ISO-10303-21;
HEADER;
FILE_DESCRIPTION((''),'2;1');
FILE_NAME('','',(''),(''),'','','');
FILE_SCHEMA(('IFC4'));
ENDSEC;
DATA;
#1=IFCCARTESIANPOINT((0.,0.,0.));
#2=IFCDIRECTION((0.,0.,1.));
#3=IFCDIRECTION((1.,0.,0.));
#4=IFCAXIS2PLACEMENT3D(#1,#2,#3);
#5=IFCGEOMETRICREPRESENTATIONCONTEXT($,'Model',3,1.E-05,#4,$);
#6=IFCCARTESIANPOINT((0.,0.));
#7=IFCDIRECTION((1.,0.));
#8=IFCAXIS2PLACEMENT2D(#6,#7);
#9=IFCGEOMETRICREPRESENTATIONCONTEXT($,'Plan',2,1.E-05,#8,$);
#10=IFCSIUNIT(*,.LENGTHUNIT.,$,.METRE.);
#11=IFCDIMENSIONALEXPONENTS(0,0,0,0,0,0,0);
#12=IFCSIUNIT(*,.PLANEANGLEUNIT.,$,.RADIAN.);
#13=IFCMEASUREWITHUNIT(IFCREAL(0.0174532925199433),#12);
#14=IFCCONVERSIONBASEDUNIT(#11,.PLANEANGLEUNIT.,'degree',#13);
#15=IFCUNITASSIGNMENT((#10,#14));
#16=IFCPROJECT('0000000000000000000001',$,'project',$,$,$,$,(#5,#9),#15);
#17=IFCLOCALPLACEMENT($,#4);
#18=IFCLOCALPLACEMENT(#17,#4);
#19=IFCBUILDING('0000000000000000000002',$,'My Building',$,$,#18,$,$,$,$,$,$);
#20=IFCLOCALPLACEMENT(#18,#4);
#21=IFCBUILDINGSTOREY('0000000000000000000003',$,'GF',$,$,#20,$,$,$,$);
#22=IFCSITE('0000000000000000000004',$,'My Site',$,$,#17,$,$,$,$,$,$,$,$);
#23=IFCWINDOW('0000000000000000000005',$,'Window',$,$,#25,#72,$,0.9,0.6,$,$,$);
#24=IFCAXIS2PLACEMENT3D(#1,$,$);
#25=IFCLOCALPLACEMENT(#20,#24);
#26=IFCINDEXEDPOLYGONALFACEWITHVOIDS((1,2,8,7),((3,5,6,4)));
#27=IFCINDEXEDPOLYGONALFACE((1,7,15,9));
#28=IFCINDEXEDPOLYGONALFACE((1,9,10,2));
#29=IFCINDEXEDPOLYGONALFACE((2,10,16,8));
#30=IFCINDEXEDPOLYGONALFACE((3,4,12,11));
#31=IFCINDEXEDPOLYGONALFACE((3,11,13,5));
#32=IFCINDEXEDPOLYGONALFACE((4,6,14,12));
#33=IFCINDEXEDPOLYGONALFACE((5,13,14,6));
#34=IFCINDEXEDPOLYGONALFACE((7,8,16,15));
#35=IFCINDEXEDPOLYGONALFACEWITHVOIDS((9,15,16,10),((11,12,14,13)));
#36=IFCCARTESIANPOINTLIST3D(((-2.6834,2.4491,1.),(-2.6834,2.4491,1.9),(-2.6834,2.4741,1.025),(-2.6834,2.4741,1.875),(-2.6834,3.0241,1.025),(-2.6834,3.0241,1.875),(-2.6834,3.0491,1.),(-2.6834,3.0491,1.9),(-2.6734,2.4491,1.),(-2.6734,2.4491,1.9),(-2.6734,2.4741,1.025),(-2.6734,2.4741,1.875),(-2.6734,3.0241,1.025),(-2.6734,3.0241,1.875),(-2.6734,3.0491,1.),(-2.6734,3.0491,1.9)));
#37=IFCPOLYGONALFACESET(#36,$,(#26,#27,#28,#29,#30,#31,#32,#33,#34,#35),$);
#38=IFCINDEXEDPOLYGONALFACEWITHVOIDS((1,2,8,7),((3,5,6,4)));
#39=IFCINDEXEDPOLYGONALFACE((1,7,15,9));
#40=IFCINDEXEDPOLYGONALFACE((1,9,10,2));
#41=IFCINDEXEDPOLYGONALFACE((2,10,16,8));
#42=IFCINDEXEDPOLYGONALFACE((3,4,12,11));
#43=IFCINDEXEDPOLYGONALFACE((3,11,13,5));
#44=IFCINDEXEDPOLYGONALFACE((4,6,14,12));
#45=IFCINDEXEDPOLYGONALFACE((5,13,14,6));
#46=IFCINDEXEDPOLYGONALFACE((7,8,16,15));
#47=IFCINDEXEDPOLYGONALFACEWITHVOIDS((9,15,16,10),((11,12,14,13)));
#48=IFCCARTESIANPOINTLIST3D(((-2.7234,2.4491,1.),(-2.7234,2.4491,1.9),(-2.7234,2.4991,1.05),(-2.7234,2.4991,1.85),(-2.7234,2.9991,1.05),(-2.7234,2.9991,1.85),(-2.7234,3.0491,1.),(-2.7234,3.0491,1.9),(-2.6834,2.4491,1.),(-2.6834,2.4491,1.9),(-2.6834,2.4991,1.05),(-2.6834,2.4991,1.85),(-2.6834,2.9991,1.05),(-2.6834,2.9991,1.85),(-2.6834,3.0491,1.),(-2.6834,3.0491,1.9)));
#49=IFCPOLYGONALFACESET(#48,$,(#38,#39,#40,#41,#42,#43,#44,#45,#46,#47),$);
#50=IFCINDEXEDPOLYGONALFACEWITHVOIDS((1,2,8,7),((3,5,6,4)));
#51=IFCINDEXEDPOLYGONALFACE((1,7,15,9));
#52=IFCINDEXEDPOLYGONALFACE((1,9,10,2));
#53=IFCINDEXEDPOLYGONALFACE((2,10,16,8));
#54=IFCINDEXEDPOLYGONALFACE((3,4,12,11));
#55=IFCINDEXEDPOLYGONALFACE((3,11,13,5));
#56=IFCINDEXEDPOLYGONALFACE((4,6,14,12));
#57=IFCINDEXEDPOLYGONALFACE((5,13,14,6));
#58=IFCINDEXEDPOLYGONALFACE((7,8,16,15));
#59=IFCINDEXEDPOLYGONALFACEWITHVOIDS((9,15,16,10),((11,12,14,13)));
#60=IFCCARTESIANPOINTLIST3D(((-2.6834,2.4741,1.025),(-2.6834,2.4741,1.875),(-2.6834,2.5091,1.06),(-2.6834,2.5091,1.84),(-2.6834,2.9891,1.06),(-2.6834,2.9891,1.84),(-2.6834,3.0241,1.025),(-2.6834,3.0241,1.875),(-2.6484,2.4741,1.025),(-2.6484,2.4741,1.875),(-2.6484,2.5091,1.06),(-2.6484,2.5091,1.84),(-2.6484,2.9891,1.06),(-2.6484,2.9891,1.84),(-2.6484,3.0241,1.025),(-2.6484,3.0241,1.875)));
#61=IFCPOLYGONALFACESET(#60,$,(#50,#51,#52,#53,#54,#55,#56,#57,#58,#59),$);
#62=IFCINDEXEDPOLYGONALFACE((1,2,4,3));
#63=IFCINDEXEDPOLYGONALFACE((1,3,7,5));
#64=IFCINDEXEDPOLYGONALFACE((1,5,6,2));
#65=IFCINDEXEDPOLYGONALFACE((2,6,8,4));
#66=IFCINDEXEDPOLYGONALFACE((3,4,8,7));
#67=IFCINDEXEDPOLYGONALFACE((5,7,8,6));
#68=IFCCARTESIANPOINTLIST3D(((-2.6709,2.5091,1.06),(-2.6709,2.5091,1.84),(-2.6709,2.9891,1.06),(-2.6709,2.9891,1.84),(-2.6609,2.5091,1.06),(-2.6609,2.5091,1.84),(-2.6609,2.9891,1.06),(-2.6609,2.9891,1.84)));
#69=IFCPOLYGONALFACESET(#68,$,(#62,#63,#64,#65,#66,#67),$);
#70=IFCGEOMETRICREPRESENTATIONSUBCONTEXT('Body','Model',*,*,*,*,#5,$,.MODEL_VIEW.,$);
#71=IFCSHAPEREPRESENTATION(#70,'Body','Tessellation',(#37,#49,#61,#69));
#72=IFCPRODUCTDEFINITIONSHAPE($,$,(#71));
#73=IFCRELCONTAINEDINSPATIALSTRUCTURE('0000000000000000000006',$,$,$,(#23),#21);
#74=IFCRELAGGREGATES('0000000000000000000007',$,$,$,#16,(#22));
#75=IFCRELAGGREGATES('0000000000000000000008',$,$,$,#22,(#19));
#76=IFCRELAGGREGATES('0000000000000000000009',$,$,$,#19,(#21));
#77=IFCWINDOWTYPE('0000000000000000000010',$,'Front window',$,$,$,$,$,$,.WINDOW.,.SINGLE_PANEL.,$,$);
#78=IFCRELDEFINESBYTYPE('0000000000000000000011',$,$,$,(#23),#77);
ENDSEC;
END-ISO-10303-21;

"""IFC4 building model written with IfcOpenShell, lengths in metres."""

from ifc_helpers import new_model, entity, si_unit, converted_unit, frame, origin_with_axes, origin_2d_with_axis, place, context, subcontext, project, spatial, line, indexed_curve, outline, extrude, shape, source, transform, mapped, type_object, type_shapes, element, save


model = new_model("IFC4")

# Units and contexts
model_context = context("Model", 3, precision=1e-05, world=origin_with_axes())
plan_context = context("Plan", 2, precision=1e-05, world=origin_2d_with_axis())
body_context_1 = subcontext(model_context, "Body", "Model", "MODEL_VIEW")
body_context_2 = subcontext(plan_context, "Body", "Plan", "PLAN_VIEW")
ifc_project = project(units=[si_unit("LENGTHUNIT", "METRE"), converted_unit("PLANEANGLEUNIT", "degree", entity("IfcReal", 0.0174532925199433), si_unit("PLANEANGLEUNIT", "RADIAN"), dimensions=[0, 0, 0, 0, 0, 0, 0])], contexts=[model_context, plan_context])

# Site, building, storey
site_placement = place(None, origin_with_axes())
site = spatial("IfcSite", under=ifc_project, at=site_placement, Name="My Site")
building_placement = place(site_placement, origin_with_axes())
building = spatial("IfcBuilding", under=site, at=building_placement, Name="My Building")
storey_placement = place(building_placement, origin_with_axes())
storey = spatial("IfcBuildingStorey", under=building, at=storey_placement, Name="GF")

# Shared definitions
window_type_1 = type_object("IfcWindowType", Name="Front window", PartitioningType="SINGLE_PANEL", PredefinedType="WINDOW")
shared_shape_1 = source(origin_with_axes(), body_context_1, "Body", "SweptSolid", [
    extrude(outline(indexed_curve([(0.0, 0.0), (0.6, 0.0), (0.6, 0.9), (0.0, 0.9)], segments=[line(1, 2, 3, 4, 1)]), holes=[indexed_curve([(0.025, 0.025), (0.575, 0.025), (0.575, 0.875), (0.025, 0.875)], segments=[line(1, 2, 3, 4, 1)])]), frame((0.0, 0.09, 0.0), z_axis=(0.0, -1.0, 0.0), x_axis=(1.0, 0.0, 0.0)), (0.0, 0.0, -1.0), 0.01),
    extrude(outline(indexed_curve([(0.0, 0.0), (0.6, 0.0), (0.6, 0.9), (0.0, 0.9)], segments=[line(1, 2, 3, 4, 1)]), holes=[indexed_curve([(0.05, 0.05), (0.55, 0.05), (0.55, 0.85), (0.05, 0.85)], segments=[line(1, 2, 3, 4, 1)])]), frame((0.0, 0.05, 0.0), z_axis=(0.0, -1.0, 0.0), x_axis=(1.0, 0.0, 0.0)), (0.0, 0.0, -1.0), 0.04),
    extrude(outline(indexed_curve([(0.0, 0.0), (0.55, 0.0), (0.55, 0.85), (0.0, 0.85)], segments=[line(1, 2, 3, 4, 1)]), holes=[indexed_curve([(0.035, 0.035), (0.515, 0.035), (0.515, 0.815), (0.035, 0.815)], segments=[line(1, 2, 3, 4, 1)])]), frame((0.025, 0.09, 0.025), z_axis=(0.0, -1.0, 0.0), x_axis=(1.0, 0.0, 0.0)), (0.0, 0.0, -1.0), 0.035),
    extrude(outline(indexed_curve([(0.035, 0.035), (0.515, 0.035), (0.515, 0.815), (0.035, 0.815)], segments=[line(1, 2, 3, 4, 1)])), frame((0.025, 0.1025, 0.025), z_axis=(0.0, -1.0, 0.0), x_axis=(1.0, 0.0, 0.0)), (0.0, 0.0, -1.0), 0.01),
])
shared_shape_2 = source(origin_with_axes(), body_context_2, "Body", "Curve2D", [
    entity("IfcIndexedPolyCurve", entity("IfcCartesianPointList2D", [[0.05, 0.05], [0.55, 0.05]])),
    entity("IfcIndexedPolyCurve", entity("IfcCartesianPointList2D", [[0.0, 0.1], [0.025, 0.1], [0.025, 0.09], [0.05, 0.09], [0.05, 0.05], [0.0, 0.05]]), [entity("IfcLineIndex", [1, 2, 3, 4, 5, 6, 1])]),
    entity("IfcIndexedPolyCurve", entity("IfcCartesianPointList2D", [[0.6, 0.1], [0.575, 0.1], [0.575, 0.09], [0.55, 0.09], [0.55, 0.05], [0.6, 0.05]]), [entity("IfcLineIndex", [1, 2, 3, 4, 5, 6, 1])]),
    entity("IfcIndexedPolyCurve", entity("IfcCartesianPointList2D", [[0.025, 0.09], [0.06, 0.09], [0.06, 0.125], [0.025, 0.125]]), [entity("IfcLineIndex", [1, 2, 3, 4, 1])]),
    entity("IfcIndexedPolyCurve", entity("IfcCartesianPointList2D", [[0.575, 0.09], [0.54, 0.09], [0.54, 0.125], [0.575, 0.125]]), [entity("IfcLineIndex", [1, 2, 3, 4, 1])]),
    entity("IfcIndexedPolyCurve", entity("IfcCartesianPointList2D", [[0.06, 0.09], [0.54, 0.09]])),
    entity("IfcIndexedPolyCurve", entity("IfcCartesianPointList2D", [[0.06, 0.125], [0.54, 0.125]])),
    entity("IfcIndexedPolyCurve", entity("IfcCartesianPointList2D", [[0.06, 0.1075], [0.54, 0.1075]])),
])
type_shapes(window_type_1, [shared_shape_1, shared_shape_2])

# Window
placement_1 = place(storey_placement, frame((-2.7734, 5.0399, 0.0), z_axis=(0.0, 0.0, 1.0), x_axis=(0.0, -1.0, 0.0)))
placement_2 = place(placement_1, frame((1.9908, 0.0, 1.0), z_axis=(0.0, 0.0, 1.0), x_axis=(1.0, 0.0, 0.0)))
window_1_placement = place(placement_2, frame((0.0, 0.0, 0.0), z_axis=(0.0, 0.0, 1.0), x_axis=(1.0, 0.0, 0.0)))
element("IfcWindow", 1, at=window_1_placement, inside=storey, type_object=window_type_1, Name="Window", OverallHeight=0.9, OverallWidth=0.6, shapes=[
    shape(body_context_1, "Body", "MappedRepresentation", [mapped(shared_shape_1, transform((0.0, 0.0, 0.0), x_axis=(1.0, 0.0, 0.0), y_axis=(0.0, 1.0, 0.0), z_axis=(0.0, 0.0, 1.0), scale=1.0))]),
    shape(body_context_2, "Body", "MappedRepresentation", [mapped(shared_shape_2, transform((0.0, 0.0, 0.0), x_axis=(1.0, 0.0, 0.0), y_axis=(0.0, 1.0, 0.0), z_axis=(0.0, 0.0, 1.0), scale=1.0))]),
])

save(model, "model.ifc")
